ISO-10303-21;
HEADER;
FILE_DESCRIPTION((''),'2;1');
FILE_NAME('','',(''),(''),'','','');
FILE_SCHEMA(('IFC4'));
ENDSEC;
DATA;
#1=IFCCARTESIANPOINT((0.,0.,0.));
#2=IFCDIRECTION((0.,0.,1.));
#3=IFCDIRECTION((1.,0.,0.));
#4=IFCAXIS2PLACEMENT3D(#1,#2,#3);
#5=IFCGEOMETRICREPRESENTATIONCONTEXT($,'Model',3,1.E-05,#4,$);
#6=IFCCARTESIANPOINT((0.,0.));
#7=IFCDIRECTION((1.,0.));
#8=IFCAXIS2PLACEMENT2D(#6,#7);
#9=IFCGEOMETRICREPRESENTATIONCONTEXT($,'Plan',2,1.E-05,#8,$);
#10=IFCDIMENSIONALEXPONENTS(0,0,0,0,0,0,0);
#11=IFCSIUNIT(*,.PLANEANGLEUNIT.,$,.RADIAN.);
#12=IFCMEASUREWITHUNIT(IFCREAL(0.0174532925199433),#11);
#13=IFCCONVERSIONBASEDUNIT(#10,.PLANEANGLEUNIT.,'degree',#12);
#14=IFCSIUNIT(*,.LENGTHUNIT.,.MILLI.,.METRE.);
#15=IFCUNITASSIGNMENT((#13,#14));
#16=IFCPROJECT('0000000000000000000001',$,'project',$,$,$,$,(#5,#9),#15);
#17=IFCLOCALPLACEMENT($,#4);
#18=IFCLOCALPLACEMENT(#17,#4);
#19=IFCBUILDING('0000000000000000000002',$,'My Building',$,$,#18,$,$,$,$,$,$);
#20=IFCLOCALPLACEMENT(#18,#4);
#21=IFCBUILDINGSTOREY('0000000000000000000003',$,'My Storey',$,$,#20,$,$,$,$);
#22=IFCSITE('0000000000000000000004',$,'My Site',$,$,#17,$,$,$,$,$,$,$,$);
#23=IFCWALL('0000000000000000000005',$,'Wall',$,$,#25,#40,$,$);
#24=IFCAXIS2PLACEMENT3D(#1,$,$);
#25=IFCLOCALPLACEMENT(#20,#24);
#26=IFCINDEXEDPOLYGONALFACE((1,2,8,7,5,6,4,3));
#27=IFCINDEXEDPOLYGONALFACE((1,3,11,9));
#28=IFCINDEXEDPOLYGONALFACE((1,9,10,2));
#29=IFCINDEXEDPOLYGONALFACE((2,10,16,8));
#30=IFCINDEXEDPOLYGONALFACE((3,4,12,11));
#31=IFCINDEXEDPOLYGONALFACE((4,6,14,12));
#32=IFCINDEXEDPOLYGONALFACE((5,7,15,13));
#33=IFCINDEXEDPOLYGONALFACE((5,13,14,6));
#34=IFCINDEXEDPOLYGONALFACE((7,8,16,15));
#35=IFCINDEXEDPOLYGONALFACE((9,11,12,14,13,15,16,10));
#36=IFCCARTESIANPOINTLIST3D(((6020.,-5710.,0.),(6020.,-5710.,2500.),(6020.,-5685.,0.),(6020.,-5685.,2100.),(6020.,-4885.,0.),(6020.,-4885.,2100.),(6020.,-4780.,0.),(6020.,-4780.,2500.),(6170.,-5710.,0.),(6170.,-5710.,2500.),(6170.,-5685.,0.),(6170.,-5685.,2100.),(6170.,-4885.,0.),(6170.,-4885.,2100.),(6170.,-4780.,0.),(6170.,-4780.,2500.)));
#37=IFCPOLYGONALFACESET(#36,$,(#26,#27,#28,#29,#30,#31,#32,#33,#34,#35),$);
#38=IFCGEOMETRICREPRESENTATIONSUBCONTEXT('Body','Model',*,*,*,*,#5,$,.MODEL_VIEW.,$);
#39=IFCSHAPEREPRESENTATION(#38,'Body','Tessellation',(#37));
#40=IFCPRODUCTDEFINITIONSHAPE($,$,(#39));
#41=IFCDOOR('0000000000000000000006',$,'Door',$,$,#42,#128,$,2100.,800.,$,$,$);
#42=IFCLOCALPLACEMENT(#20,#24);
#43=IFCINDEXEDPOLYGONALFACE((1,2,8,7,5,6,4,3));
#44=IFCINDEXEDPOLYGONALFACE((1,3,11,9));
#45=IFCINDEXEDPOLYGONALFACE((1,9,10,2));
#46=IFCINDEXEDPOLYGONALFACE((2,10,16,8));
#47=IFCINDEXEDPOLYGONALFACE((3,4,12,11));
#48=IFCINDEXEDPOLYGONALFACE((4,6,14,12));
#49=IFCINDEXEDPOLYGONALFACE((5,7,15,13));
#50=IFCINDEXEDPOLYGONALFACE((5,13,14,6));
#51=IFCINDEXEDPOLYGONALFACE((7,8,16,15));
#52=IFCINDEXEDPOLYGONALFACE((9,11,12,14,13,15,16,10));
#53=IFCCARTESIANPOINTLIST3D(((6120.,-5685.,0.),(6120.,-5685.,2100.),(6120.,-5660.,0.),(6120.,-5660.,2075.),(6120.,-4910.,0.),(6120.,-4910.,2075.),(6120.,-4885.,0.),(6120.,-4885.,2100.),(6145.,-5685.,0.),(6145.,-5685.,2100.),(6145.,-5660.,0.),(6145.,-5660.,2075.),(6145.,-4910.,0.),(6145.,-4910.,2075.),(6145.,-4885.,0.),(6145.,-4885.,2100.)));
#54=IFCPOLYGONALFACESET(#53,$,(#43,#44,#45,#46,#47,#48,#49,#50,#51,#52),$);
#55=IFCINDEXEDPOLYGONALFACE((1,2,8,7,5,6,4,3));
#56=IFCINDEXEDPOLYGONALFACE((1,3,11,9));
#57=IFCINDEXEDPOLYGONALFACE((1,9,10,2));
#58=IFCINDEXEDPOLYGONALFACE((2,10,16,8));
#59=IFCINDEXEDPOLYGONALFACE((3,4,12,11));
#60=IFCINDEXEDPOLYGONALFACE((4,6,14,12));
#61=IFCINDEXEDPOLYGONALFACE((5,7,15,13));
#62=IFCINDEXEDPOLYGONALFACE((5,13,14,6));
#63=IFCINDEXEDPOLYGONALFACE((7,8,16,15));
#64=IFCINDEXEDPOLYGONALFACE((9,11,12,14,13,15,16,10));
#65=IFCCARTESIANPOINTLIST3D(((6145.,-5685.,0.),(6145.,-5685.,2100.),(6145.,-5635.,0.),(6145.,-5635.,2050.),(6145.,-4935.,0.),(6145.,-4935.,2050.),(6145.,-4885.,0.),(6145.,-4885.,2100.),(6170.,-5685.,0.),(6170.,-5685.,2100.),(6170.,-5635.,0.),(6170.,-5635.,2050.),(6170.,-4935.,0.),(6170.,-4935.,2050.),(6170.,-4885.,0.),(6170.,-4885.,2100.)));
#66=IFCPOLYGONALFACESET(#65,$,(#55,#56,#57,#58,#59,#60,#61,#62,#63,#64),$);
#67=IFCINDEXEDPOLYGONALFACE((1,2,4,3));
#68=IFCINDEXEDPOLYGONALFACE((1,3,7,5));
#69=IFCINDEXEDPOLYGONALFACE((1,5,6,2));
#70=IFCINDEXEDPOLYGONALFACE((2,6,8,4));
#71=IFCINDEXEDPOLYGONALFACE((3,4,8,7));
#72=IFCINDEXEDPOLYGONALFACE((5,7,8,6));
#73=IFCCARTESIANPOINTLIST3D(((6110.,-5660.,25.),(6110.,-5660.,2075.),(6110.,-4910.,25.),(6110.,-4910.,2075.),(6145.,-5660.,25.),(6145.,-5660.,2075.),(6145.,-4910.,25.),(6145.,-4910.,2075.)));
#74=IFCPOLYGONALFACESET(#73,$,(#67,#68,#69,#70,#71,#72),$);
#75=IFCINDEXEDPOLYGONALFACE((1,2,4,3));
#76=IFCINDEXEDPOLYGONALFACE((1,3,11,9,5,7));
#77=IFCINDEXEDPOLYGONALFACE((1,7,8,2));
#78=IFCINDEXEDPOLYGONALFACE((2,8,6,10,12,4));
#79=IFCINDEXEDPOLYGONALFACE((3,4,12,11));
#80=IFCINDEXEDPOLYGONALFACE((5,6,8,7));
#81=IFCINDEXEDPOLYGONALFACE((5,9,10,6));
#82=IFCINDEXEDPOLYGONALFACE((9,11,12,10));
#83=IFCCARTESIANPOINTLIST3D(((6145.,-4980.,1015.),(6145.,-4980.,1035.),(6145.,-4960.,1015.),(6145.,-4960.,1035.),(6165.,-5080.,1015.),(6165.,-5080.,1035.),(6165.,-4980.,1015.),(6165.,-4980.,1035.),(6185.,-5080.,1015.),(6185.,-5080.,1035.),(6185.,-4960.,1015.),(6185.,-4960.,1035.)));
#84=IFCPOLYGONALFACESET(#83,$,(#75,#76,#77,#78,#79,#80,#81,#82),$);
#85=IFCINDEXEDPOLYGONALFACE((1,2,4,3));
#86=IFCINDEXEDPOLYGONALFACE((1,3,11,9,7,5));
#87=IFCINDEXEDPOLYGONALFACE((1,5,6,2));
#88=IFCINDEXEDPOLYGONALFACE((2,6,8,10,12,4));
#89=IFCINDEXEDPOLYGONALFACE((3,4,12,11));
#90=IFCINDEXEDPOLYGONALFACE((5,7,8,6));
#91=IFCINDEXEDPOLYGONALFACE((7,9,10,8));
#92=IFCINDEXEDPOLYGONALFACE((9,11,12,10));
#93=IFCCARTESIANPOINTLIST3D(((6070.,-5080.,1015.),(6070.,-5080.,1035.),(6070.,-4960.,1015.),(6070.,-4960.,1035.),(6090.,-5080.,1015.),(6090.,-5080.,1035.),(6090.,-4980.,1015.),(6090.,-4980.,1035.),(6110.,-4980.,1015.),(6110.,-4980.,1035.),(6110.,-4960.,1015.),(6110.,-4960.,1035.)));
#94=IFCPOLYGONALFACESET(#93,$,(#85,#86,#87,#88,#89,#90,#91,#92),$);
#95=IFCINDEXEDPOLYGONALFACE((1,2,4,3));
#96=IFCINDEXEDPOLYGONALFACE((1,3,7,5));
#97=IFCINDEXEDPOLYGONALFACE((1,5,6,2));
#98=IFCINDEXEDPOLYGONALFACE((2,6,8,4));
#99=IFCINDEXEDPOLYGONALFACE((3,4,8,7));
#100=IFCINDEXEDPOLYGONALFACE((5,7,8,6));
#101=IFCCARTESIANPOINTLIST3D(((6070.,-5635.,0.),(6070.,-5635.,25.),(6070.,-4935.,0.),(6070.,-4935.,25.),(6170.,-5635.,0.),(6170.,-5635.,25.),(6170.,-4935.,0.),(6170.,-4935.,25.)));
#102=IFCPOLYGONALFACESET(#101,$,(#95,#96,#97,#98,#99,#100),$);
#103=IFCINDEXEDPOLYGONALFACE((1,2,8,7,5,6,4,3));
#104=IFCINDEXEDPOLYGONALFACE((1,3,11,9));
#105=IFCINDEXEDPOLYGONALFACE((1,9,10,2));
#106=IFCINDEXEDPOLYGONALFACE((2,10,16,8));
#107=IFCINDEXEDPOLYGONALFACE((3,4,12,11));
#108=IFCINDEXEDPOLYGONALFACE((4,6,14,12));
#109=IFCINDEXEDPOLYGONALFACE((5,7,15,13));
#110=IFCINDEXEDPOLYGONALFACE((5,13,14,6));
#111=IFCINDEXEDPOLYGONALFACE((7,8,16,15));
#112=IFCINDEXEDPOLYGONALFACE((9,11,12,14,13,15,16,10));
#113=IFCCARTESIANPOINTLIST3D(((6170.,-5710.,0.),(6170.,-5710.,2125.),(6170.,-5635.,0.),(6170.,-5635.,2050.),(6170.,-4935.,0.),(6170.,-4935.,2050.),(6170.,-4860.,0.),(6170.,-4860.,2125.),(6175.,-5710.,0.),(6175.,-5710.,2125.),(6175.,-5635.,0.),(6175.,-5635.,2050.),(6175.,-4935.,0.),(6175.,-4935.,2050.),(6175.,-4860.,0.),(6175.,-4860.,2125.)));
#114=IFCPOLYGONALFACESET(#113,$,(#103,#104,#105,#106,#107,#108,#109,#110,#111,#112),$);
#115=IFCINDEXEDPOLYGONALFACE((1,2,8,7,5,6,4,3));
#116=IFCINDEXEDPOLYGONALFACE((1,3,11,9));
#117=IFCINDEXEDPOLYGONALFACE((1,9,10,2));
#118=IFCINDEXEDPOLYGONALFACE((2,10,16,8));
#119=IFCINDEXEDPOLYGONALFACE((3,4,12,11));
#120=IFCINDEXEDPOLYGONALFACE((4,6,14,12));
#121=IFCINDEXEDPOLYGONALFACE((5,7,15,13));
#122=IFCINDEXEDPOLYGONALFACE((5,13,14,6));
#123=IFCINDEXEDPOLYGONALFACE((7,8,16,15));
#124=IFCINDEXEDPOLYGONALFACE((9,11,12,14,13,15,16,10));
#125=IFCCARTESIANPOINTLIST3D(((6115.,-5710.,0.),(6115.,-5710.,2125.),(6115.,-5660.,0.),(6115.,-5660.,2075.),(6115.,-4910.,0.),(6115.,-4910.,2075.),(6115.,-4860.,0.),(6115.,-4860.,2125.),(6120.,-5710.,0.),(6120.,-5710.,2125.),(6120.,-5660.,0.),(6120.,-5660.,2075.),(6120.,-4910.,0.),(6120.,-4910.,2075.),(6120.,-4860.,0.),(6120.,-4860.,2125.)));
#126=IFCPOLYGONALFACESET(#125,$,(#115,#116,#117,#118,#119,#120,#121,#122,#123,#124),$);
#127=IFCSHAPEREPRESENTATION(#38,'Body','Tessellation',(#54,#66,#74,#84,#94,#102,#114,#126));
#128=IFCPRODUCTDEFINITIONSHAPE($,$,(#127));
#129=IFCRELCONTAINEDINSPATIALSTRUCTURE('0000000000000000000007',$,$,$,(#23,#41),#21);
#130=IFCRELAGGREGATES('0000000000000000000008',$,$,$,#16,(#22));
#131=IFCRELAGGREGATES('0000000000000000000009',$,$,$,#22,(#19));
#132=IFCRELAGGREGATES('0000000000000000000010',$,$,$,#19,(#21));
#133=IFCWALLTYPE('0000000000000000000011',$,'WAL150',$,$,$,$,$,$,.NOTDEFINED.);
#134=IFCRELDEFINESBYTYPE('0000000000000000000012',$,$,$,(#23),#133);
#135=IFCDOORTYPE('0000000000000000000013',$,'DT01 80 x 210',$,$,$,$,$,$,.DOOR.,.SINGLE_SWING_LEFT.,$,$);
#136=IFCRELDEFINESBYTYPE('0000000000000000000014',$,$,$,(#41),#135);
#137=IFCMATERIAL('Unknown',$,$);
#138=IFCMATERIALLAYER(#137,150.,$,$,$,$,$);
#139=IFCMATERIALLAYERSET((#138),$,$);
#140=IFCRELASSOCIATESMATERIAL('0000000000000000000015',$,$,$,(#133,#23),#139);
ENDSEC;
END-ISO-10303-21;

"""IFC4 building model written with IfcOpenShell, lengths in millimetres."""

from ifc_helpers import new_model, entity, si_unit, converted_unit, frame, origin_with_axes, origin_2d_with_axis, place, context, subcontext, project, spatial, line, indexed_curve, outline, extrude, shape, source, transform, mapped, material, layer, layer_set, layer_usage, type_object, type_shapes, element, fill, save


model = new_model("IFC4")

# Units and contexts
model_context = context("Model", 3, precision=1e-05, world=origin_with_axes())
plan_context = context("Plan", 2, precision=1e-05, world=origin_2d_with_axis())
body_context_1 = subcontext(model_context, "Body", "Model", "MODEL_VIEW")
body_context_2 = subcontext(plan_context, "Body", "Plan", "PLAN_VIEW")
ifc_project = project(units=[converted_unit("PLANEANGLEUNIT", "degree", entity("IfcReal", 0.0174532925199433), si_unit("PLANEANGLEUNIT", "RADIAN"), dimensions=[0, 0, 0, 0, 0, 0, 0]), si_unit("LENGTHUNIT", "METRE", prefix="MILLI")], contexts=[model_context, plan_context])

# Site, building, storey
site_placement = place(None, origin_with_axes())
site = spatial("IfcSite", under=ifc_project, at=site_placement, Name="My Site")
building_placement = place(site_placement, origin_with_axes())
building = spatial("IfcBuilding", under=site, at=building_placement, Name="My Building")
storey_placement = place(building_placement, origin_with_axes())
storey = spatial("IfcBuildingStorey", under=building, at=storey_placement, Name="My Storey")

# Shared definitions
ifc_material = material(Name="Unknown")

# Shared definitions
ifc_layer_1 = layer(ifc_material, 150.0)
ifc_layer_set_1 = layer_set([ifc_layer_1])
wall_type_1 = type_object("IfcWallType", Name="WAL150", PredefinedType="NOTDEFINED", material=ifc_layer_set_1)

# Shared definitions
shared_shape_1 = source(origin_with_axes(), body_context_1, "Body", "SweptSolid", [
    extrude(outline(indexed_curve([(0.0, 0.0), (800.0, 0.0), (800.0, 2100.0), (0.0, 2100.0)], segments=[line(1, 2, 3, 4, 1)])), frame((0.0, -600.0, 0.0), z_axis=(0.0, -1.0, 0.0), x_axis=(1.0, 0.0, 0.0)), (0.0, 0.0, -1.0), 1200.0),
])
door_type = type_object("IfcDoorType", Name="DT01 80 x 210", OperationType="SINGLE_SWING_LEFT", PredefinedType="DOOR")
shared_shape_2 = source(origin_with_axes(), body_context_1, "Body", "SweptSolid", [
    extrude(outline(indexed_curve([(0.0, 0.0), (0.0, 2100.0), (800.0, 2100.0), (800.0, 0.0), (775.0, 0.0), (775.0, 2075.0), (25.0, 2075.0), (25.0, 0.0)], segments=[line(1, 2, 3, 4, 5, 6, 7, 8, 1)])), frame((0.0, 25.0, 0.0), z_axis=(0.0, -1.0, 0.0), x_axis=(1.0, 0.0, 0.0)), (0.0, 0.0, -1.0), 25.0),
    extrude(outline(indexed_curve([(0.0, 0.0), (0.0, 2100.0), (800.0, 2100.0), (800.0, 0.0), (750.0, 0.0), (750.0, 2050.0), (50.0, 2050.0), (50.0, 0.0)], segments=[line(1, 2, 3, 4, 5, 6, 7, 8, 1)])), frame((0.0, 0.0, 0.0), z_axis=(0.0, -1.0, 0.0), x_axis=(1.0, 0.0, 0.0)), (0.0, 0.0, -1.0), 25.0),
    extrude(outline(indexed_curve([(0.0, 0.0), (750.0, 0.0), (750.0, 35.0), (0.0, 35.0)], segments=[line(1, 2, 3, 4, 1)])), frame((25.0, 25.0, 25.0), z_axis=(0.0, 0.0, 1.0), x_axis=(1.0, 0.0, 0.0)), (0.0, 0.0, 1.0), 2050.0),
    extrude(outline(indexed_curve([(0.0, 0.0), (0.0, -40.0), (-120.0, -40.0), (-120.0, -20.0), (-20.0, -20.0), (-20.0, 0.0)], segments=[line(1, 2, 3, 4, 5, 6, 1)])), frame((725.0, 25.0, 1015.0), z_axis=(0.0, 0.0, 1.0), x_axis=(1.0, 0.0, 0.0)), (0.0, 0.0, 1.0), 20.0),
    extrude(outline(indexed_curve([(0.0, 0.0), (0.0, 40.0), (-120.0, 40.0), (-120.0, 20.0), (-20.0, 20.0), (-20.0, 0.0)], segments=[line(1, 2, 3, 4, 5, 6, 1)])), frame((725.0, 60.0, 1015.0), z_axis=(0.0, 0.0, 1.0), x_axis=(1.0, 0.0, 0.0)), (0.0, 0.0, 1.0), 20.0),
    extrude(outline(indexed_curve([(0.0, 0.0), (700.0, 0.0), (700.0, 100.0), (0.0, 100.0), (0.0, 0.0)])), frame((50.0, 0.0, 0.0), z_axis=(0.0, 0.0, 1.0), x_axis=(1.0, 0.0, 0.0)), (0.0, 0.0, 1.0), 25.0),
    extrude(outline(indexed_curve([(75.0, 0.0), (75.0, 2050.0), (775.0, 2050.0), (775.0, 0.0), (850.0, 0.0), (850.0, 2125.0), (0.0, 2125.0), (0.0, 0.0), (75.0, 0.0)])), frame((-25.0, -5.0, 0.0), z_axis=(0.0, -1.0, 0.0), x_axis=(1.0, 0.0, 0.0)), (0.0, 0.0, -1.0), 5.0),
    extrude(outline(indexed_curve([(50.0, 0.0), (50.0, 2075.0), (800.0, 2075.0), (800.0, 0.0), (850.0, 0.0), (850.0, 2125.0), (0.0, 2125.0), (0.0, 0.0), (50.0, 0.0)])), frame((-25.0, 50.0, 0.0), z_axis=(0.0, -1.0, 0.0), x_axis=(1.0, 0.0, 0.0)), (0.0, 0.0, -1.0), 5.0),
])
shared_shape_3 = source(origin_with_axes(), body_context_2, "Body", "Curve2D", [
    entity("IfcIndexedPolyCurve", entity("IfcCartesianPointList2D", [[0.0, 0.0], [0.0, 50.0], [25.0, 50.0], [25.0, 25.0], [50.0, 25.0], [50.0, 0.0]]), [entity("IfcLineIndex", [1, 2, 3, 4, 5, 6, 1])]),
    entity("IfcIndexedPolyCurve", entity("IfcCartesianPointList2D", [[800.0, 0.0], [800.0, 50.0], [775.0, 50.0], [775.0, 25.0], [750.0, 25.0], [750.0, 0.0]]), [entity("IfcLineIndex", [1, 2, 3, 4, 5, 6, 1])]),
    entity("IfcTrimmedCurve", entity("IfcEllipse", entity("IfcAxis2Placement2D", entity("IfcCartesianPoint", [60.0, 50.0]), entity("IfcDirection", [1.0, 0.0])), 715.0, 750.0), [entity("IfcCartesianPoint", [775.0, 50.0])], [entity("IfcCartesianPoint", [60.0, 800.0])], True, "CARTESIAN"),
    entity("IfcIndexedPolyCurve", entity("IfcCartesianPointList2D", [[25.0, 50.0], [60.0, 50.0], [60.0, 800.0], [25.0, 800.0]]), [entity("IfcLineIndex", [1, 2, 3, 4, 1])]),
])
type_shapes(door_type, [shared_shape_2, shared_shape_3])

# Wall, opening, door
ifc_layer_usage_1 = layer_usage(ifc_layer_set_1, "AXIS2", "POSITIVE", 0.0)
wall_1_placement = place(storey_placement, frame((6170.0, -5710.0, 0.0), z_axis=(0.0, 0.0, 1.0), x_axis=(0.0, 1.0, 0.0)))
wall_1 = element("IfcWall", 1, at=wall_1_placement, inside=storey, type_object=wall_type_1, material=ifc_layer_usage_1, Name="Wall", context=body_context_1, shape_type="SweptSolid", body=[
    extrude(outline(indexed_curve([(0.0, 0.0), (0.0, 150.0), (930.0, 150.0), (930.0, 0.0)], segments=[line(1, 2, 3, 4, 1)])), origin_with_axes(), (0.0, 0.0, 1.0), 2500.0),
])
opening_1_placement = place(wall_1_placement, frame((25.0, 0.0, 0.0), z_axis=(0.0, 0.0, 1.0), x_axis=(1.0, 0.0, 0.0)))
opening_1 = element("IfcOpeningElement", 2, at=opening_1_placement, cuts=wall_1, PredefinedType="OPENING", context=body_context_1, shape_type="MappedRepresentation", body=[
    mapped(shared_shape_1, transform((0.0, 0.0, 0.0), x_axis=(1.0, 0.0, 0.0), y_axis=(0.0, 1.0, 0.0), z_axis=(0.0, 0.0, 1.0), scale=1.0)),
])
door_1_placement = place(opening_1_placement, frame((0.0, 0.0, 0.0), z_axis=(0.0, 0.0, 1.0), x_axis=(1.0, 0.0, 0.0)))
door_1 = element("IfcDoor", 3, at=door_1_placement, inside=storey, type_object=door_type, Name="Door", OverallHeight=2100.0, OverallWidth=800.0, shapes=[
    shape(body_context_1, "Body", "MappedRepresentation", [mapped(shared_shape_2, transform((0.0, 0.0, 0.0), x_axis=(1.0, 0.0, 0.0), y_axis=(0.0, 1.0, 0.0), z_axis=(0.0, 0.0, 1.0), scale=1.0))]),
    shape(body_context_2, "Body", "MappedRepresentation", [mapped(shared_shape_3, transform((0.0, 0.0, 0.0), x_axis=(1.0, 0.0, 0.0), y_axis=(0.0, 1.0, 0.0), z_axis=(0.0, 0.0, 1.0), scale=1.0))]),
])
fill(opening_1, door_1)

save(model, "model.ifc")
